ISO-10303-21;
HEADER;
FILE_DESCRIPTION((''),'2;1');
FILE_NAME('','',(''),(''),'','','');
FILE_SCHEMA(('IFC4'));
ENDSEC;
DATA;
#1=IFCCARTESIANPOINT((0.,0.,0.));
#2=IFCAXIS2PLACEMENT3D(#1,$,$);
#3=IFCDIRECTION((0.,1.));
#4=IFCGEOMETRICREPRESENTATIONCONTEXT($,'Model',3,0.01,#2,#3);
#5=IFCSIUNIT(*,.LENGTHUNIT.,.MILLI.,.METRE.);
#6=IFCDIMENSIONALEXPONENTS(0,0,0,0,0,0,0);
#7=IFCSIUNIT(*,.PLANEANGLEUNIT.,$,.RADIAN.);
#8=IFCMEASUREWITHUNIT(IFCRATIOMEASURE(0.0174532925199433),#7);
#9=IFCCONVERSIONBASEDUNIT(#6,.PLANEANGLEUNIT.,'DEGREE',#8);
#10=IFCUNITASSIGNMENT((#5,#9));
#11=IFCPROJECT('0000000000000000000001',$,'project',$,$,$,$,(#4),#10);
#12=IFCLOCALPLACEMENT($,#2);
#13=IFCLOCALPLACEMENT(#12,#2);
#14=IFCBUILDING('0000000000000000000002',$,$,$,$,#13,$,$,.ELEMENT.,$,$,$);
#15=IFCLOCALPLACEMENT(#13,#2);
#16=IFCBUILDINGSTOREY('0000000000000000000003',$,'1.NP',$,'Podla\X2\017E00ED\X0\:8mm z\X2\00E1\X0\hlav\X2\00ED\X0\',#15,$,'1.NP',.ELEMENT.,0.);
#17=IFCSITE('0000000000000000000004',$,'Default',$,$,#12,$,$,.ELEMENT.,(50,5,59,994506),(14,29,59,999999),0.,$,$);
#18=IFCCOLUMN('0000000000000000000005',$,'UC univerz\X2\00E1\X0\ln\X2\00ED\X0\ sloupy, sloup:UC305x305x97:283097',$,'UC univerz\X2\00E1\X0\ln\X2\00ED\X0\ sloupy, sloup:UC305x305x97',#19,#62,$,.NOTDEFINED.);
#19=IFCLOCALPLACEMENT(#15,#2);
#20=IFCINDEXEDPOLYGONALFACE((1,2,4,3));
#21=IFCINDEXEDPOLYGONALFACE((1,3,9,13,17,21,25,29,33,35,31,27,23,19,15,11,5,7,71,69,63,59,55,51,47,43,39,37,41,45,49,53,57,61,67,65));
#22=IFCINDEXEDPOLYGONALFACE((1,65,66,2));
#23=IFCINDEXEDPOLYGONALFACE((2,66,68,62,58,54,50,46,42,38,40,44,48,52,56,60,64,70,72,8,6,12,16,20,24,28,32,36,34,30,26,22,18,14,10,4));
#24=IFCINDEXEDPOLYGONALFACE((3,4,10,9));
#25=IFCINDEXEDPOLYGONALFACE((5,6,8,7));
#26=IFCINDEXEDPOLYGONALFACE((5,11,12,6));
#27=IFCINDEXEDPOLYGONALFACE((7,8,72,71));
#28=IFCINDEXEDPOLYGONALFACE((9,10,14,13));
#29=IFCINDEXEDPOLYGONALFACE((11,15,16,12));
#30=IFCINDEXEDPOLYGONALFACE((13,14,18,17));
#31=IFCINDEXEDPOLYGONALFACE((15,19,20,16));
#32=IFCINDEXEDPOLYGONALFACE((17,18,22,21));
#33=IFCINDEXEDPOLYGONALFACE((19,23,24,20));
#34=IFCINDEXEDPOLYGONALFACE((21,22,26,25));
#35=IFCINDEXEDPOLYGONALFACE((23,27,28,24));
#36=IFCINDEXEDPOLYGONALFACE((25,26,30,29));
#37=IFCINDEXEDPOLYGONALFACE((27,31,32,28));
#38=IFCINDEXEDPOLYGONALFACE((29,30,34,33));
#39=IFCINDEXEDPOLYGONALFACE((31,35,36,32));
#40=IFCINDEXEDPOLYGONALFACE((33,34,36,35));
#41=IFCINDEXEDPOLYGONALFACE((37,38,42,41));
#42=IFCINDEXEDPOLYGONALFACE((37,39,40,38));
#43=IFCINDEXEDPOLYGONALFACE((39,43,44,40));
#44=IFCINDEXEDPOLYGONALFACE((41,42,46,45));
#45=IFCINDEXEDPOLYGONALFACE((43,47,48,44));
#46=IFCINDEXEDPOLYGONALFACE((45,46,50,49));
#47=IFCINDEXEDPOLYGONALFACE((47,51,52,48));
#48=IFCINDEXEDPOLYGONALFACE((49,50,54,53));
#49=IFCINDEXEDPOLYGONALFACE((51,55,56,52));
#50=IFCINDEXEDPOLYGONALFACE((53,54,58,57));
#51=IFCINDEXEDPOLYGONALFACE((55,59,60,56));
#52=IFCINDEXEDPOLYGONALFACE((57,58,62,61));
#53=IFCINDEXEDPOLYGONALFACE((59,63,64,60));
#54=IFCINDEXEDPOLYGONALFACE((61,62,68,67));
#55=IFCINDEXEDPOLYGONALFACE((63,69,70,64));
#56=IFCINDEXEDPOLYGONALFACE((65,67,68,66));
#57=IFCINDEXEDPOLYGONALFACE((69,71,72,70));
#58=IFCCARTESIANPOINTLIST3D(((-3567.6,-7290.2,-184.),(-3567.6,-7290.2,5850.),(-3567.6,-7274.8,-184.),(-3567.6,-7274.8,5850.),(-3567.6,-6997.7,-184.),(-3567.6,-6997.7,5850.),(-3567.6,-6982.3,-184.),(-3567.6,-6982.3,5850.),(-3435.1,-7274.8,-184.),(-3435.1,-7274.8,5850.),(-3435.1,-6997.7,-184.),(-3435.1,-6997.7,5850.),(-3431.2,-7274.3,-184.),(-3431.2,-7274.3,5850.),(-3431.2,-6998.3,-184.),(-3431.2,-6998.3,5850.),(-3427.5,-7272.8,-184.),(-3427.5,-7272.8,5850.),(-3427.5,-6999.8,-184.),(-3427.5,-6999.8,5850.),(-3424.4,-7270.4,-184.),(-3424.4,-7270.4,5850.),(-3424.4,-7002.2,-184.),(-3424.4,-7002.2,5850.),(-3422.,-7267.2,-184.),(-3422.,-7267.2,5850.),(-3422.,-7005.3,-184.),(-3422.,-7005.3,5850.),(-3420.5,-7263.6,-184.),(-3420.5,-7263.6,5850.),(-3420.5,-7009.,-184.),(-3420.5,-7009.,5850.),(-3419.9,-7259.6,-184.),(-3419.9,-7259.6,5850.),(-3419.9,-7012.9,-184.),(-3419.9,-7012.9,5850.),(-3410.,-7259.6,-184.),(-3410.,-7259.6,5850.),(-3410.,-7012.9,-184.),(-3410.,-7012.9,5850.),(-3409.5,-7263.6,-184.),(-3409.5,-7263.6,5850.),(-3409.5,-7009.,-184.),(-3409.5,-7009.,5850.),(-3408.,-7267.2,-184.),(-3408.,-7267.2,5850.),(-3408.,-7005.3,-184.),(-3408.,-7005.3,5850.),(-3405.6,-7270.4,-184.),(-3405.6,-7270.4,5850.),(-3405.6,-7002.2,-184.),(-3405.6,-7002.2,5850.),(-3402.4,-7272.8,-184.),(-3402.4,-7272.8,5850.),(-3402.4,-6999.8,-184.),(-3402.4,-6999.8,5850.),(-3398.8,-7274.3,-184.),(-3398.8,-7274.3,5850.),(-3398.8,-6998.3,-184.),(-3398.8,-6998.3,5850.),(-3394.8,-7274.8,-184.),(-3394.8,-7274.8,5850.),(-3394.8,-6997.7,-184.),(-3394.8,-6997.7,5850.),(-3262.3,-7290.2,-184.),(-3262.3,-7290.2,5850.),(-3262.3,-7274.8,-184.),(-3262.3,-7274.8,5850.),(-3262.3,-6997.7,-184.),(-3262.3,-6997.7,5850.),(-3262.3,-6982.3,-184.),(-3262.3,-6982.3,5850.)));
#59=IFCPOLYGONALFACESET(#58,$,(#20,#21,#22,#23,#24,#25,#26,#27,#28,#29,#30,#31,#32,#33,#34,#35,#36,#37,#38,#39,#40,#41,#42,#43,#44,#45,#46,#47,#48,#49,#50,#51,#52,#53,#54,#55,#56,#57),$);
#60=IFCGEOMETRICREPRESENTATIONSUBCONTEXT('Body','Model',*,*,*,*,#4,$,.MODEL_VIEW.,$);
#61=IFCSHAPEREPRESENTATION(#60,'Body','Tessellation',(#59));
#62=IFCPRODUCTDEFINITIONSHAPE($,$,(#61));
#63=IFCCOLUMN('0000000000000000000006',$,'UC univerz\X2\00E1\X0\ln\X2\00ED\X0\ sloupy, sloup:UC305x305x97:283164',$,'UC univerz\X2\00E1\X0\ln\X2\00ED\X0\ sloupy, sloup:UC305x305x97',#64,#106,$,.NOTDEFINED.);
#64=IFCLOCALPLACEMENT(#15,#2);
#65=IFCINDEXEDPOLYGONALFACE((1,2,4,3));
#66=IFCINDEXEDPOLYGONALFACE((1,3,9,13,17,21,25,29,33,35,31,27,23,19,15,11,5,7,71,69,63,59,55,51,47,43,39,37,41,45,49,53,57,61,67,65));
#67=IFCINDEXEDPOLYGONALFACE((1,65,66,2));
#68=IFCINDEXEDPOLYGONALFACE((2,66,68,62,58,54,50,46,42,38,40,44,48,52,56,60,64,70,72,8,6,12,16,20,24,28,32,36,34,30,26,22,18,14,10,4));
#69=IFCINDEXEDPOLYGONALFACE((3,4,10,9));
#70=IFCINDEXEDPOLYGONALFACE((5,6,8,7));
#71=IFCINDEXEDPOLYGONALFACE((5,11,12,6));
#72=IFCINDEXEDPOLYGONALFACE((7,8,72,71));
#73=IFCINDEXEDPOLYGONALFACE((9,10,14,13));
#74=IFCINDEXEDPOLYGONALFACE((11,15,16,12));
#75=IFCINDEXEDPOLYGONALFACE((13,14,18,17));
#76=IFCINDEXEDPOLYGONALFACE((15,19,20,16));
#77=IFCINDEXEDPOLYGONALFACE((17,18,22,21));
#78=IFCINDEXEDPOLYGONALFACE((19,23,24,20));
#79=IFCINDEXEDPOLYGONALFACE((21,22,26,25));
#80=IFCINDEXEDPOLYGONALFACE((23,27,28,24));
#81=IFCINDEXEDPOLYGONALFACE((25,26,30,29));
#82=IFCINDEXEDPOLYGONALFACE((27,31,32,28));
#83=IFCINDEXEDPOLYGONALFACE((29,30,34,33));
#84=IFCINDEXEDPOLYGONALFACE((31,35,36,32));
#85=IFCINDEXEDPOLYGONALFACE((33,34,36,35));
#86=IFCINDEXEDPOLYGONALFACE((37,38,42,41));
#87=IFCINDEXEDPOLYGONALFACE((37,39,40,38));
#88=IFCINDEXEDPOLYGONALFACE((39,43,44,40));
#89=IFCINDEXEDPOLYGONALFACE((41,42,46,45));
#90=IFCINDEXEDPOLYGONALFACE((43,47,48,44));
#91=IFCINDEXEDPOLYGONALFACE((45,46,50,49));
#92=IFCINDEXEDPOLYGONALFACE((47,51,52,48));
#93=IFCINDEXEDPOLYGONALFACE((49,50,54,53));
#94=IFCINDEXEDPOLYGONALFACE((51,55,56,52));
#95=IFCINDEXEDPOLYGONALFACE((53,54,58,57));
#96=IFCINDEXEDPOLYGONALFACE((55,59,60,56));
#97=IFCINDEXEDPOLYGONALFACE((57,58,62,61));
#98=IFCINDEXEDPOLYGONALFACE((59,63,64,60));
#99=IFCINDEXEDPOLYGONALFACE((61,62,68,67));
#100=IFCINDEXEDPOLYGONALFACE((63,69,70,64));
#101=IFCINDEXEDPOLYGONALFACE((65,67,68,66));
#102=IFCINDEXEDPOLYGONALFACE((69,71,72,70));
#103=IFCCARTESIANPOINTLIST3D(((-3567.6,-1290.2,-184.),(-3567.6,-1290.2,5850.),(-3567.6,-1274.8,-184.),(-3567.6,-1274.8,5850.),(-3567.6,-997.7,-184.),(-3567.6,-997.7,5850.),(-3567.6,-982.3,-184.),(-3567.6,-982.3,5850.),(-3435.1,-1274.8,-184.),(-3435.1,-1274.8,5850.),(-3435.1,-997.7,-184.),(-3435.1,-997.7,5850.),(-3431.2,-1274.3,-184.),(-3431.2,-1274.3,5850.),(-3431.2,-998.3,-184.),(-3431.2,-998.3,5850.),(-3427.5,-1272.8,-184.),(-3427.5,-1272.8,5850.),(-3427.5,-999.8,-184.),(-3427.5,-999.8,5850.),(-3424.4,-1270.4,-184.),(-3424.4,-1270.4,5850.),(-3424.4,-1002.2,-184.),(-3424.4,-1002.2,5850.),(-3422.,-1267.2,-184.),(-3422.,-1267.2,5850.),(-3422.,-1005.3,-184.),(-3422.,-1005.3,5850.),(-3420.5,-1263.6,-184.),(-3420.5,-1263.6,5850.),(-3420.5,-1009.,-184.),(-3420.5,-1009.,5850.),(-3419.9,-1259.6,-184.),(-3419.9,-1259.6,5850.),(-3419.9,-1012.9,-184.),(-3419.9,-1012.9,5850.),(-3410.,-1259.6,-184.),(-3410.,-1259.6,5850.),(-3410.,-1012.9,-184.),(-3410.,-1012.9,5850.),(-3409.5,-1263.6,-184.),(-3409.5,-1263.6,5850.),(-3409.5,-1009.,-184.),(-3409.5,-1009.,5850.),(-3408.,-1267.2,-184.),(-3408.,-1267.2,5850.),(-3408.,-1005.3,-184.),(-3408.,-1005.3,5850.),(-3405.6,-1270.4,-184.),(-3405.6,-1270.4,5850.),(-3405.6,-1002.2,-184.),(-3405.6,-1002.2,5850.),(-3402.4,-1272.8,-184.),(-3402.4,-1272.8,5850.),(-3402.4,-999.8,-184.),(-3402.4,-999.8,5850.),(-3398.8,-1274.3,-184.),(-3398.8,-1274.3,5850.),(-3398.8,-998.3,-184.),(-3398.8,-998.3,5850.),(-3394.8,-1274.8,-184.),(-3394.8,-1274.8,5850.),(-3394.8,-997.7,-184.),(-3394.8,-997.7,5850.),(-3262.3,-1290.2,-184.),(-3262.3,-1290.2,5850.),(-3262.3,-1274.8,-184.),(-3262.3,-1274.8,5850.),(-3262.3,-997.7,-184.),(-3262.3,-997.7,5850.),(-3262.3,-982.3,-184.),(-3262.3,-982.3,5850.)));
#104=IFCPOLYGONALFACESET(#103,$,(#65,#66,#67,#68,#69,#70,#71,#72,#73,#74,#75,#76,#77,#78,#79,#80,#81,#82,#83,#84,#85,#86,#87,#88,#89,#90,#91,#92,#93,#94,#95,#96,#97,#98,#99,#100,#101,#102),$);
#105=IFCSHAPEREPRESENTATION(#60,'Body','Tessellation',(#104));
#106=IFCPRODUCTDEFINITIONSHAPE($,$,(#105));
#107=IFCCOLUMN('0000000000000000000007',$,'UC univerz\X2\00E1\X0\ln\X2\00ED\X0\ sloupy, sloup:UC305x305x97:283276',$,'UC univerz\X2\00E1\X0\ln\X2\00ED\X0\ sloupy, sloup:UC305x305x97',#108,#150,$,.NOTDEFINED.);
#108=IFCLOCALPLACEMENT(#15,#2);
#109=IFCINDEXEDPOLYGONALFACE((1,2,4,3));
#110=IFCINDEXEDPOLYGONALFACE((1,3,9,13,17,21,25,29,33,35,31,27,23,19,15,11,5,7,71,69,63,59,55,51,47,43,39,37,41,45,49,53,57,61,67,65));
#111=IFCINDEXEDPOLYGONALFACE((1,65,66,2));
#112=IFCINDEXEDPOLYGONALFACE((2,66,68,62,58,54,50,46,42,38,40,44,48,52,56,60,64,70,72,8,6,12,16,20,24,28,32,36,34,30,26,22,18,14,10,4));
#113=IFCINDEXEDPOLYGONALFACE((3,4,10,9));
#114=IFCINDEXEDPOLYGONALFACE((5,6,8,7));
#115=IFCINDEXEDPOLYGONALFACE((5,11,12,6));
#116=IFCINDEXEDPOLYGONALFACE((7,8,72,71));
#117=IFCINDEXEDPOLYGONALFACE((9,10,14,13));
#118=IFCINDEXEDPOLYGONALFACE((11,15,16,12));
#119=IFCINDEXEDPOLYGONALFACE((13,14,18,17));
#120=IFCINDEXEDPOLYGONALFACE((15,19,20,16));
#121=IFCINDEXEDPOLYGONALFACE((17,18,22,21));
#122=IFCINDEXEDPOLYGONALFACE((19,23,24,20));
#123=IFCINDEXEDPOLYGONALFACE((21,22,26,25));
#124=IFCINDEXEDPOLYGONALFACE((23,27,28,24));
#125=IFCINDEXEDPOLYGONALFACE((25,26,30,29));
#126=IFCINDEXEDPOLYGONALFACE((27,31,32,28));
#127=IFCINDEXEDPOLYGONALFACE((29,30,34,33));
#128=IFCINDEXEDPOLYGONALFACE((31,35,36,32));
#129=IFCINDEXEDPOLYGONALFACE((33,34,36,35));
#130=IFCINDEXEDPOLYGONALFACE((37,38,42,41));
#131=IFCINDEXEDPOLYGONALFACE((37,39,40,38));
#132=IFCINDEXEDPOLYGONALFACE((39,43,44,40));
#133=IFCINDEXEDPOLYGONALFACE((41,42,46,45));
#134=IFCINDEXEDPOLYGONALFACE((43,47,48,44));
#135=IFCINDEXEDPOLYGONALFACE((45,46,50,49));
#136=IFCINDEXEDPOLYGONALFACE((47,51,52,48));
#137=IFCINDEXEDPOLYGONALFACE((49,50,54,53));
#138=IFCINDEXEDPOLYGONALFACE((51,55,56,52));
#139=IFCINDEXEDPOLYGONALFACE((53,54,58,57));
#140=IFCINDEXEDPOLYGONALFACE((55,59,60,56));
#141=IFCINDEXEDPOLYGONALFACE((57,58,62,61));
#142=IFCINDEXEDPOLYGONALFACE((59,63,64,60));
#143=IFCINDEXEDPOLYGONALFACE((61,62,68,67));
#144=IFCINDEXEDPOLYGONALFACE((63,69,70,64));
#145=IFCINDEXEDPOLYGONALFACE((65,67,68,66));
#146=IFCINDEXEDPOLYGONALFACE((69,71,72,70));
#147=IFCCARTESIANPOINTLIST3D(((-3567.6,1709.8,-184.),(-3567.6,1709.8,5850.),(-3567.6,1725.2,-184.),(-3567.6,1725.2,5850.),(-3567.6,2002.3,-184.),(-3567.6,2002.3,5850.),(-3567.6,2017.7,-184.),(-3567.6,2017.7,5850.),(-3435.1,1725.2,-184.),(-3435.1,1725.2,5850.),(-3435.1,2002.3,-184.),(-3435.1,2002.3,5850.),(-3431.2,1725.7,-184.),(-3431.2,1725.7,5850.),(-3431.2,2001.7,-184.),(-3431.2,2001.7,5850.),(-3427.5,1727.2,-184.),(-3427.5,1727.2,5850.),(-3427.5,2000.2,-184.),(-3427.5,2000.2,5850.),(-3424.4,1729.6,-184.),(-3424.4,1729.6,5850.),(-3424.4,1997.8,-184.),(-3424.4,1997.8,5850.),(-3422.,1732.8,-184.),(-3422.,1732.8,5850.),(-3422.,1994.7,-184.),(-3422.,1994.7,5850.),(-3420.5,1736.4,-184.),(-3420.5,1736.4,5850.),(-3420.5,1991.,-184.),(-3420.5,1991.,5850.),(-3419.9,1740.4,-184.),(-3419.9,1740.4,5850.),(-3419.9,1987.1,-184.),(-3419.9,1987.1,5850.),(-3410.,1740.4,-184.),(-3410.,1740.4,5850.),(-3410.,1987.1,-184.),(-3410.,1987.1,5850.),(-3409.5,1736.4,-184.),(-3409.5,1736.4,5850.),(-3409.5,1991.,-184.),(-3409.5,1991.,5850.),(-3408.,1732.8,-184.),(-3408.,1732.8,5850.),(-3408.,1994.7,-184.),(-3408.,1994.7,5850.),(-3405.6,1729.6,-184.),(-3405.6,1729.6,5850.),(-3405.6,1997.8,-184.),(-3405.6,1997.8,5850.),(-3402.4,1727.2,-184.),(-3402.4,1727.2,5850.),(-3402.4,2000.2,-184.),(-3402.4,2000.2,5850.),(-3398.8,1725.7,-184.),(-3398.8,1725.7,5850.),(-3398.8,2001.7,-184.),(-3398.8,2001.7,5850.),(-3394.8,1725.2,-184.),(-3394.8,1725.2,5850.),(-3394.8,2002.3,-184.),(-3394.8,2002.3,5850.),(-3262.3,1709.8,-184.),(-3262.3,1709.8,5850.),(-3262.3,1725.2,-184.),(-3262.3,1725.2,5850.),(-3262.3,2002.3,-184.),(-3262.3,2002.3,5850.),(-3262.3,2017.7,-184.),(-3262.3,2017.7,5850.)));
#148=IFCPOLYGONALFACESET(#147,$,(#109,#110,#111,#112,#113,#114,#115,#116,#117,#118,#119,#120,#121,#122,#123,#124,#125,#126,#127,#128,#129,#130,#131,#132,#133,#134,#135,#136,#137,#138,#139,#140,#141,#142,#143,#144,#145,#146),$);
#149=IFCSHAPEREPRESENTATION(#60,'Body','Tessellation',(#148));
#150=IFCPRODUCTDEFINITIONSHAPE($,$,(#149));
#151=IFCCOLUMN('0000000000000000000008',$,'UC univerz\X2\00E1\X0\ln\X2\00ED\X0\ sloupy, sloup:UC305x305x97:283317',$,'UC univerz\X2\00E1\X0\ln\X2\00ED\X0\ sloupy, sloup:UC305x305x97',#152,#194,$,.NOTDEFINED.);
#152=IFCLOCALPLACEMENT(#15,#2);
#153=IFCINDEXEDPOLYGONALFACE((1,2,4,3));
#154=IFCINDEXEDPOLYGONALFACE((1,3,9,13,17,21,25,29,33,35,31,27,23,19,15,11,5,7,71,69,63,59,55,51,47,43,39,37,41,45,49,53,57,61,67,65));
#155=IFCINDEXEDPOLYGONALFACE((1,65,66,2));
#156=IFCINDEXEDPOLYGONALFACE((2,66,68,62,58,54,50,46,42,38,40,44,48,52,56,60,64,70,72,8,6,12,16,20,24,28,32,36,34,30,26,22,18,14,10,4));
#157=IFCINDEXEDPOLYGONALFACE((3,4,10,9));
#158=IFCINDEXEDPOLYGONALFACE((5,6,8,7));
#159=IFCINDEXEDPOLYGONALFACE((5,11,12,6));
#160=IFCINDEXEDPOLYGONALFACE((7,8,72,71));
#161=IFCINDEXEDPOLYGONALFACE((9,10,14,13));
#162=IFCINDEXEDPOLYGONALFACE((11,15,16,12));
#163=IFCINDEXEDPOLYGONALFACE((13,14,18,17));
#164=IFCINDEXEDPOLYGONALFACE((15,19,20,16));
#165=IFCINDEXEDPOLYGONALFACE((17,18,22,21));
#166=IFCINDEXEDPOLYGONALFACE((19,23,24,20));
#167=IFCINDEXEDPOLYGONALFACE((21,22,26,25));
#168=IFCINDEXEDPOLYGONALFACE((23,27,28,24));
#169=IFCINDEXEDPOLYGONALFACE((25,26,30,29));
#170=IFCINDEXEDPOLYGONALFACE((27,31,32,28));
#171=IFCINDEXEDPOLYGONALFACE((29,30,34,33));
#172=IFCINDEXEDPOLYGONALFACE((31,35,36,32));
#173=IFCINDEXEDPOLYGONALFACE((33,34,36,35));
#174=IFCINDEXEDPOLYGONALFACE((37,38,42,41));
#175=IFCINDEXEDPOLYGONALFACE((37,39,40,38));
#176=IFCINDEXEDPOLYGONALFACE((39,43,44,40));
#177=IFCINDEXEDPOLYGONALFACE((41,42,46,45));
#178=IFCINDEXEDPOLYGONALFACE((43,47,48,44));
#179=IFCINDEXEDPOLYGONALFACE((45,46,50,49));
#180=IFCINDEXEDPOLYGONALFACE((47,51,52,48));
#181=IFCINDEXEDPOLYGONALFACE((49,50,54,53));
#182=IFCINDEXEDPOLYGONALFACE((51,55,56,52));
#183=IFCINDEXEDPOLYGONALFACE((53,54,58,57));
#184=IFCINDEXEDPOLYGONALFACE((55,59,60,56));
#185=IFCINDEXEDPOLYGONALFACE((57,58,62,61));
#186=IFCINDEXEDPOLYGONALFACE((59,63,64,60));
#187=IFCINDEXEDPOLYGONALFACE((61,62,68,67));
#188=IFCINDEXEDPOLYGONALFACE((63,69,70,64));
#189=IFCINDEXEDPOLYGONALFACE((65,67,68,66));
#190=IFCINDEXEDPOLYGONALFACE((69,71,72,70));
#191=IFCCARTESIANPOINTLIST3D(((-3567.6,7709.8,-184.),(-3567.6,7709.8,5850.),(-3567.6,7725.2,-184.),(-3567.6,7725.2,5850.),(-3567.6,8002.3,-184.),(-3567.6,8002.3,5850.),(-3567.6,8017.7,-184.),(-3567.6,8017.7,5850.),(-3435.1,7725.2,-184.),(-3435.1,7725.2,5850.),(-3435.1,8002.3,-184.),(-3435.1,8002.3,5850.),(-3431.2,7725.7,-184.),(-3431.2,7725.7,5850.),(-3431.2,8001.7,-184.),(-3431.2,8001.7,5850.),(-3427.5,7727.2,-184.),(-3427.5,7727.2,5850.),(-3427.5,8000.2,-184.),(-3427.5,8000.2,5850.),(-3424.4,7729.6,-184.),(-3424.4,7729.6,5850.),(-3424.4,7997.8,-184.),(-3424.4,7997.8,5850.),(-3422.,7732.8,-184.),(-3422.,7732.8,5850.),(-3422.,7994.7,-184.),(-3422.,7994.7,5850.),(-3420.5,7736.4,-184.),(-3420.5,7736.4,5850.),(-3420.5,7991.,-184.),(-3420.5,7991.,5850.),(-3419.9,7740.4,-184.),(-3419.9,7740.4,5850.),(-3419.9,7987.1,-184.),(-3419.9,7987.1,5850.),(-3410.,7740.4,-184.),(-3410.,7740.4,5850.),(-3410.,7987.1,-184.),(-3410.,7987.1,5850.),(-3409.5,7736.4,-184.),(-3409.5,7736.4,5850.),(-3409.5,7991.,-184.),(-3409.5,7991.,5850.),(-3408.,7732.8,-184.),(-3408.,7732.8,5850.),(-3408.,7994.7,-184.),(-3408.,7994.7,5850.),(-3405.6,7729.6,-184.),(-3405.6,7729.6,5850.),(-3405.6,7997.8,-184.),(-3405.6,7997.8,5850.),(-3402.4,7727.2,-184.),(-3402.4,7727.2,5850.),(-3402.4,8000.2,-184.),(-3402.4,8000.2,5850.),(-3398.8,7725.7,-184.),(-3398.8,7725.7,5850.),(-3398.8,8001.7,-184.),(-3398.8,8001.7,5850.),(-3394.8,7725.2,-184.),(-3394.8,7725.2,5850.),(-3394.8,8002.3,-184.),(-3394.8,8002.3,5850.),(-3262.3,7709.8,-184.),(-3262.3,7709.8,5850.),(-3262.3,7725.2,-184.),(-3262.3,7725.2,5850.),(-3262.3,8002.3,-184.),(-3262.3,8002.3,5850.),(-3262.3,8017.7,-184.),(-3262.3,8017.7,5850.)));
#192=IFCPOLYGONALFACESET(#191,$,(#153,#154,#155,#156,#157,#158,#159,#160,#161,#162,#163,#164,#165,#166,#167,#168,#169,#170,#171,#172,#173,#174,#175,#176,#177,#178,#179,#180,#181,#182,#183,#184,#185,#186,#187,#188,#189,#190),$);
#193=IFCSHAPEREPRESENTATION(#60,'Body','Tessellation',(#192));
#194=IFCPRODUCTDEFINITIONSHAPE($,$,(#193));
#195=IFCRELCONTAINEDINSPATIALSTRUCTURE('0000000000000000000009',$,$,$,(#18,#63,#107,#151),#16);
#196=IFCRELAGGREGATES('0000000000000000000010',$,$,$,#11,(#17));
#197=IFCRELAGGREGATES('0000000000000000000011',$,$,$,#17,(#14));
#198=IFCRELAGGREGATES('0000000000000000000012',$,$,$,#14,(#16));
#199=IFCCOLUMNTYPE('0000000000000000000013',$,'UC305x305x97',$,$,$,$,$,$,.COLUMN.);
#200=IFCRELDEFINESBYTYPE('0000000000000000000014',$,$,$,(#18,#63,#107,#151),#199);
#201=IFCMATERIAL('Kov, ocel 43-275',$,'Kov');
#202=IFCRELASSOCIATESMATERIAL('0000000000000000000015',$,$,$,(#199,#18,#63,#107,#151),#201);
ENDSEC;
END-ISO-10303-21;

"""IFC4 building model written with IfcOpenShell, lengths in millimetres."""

from ifc_helpers import new_model, entity, si_unit, converted_unit, direction, frame, frame_2d, origin, place, context, subcontext, project, spatial, i_section, extrude, source, transform, mapped, material, material_profile, profile_set, profile_usage, type_object, type_shapes, element, save


model = new_model("IFC4")

# Units and contexts
model_context = context("Model", 3, precision=0.01, world=origin(), true_north=direction((0.0, 1.0)))
body_context = subcontext(model_context, "Body", "Model", "MODEL_VIEW")
ifc_project = project(units=[si_unit("LENGTHUNIT", "METRE", prefix="MILLI"), converted_unit("PLANEANGLEUNIT", "DEGREE", entity("IfcRatioMeasure", 0.0174532925199433), si_unit("PLANEANGLEUNIT", "RADIAN"), dimensions=[0, 0, 0, 0, 0, 0, 0])], contexts=[model_context])

# Site, building, storey
site_placement = place(None, origin())
site = spatial("IfcSite", under=ifc_project, at=site_placement, Name="Default", CompositionType="ELEMENT", RefLatitude=(50, 5, 59, 994506), RefLongitude=(14, 29, 59, 999999), RefElevation=0.0)
building_placement = place(site_placement, origin())
building = spatial("IfcBuilding", under=site, at=building_placement, CompositionType="ELEMENT")
storey_placement = place(building_placement, origin())
storey = spatial("IfcBuildingStorey", under=building, at=storey_placement, Name="1.NP", ObjectType="Podlaží:8mm záhlaví", LongName="1.NP", CompositionType="ELEMENT", Elevation=0.0)

# Columns
ifc_material_1 = material(Name="Kov, ocel 43-275", Category="Kov")
ifc_material_profile = material_profile(ifc_material_1, i_section(OverallWidth=305.3, OverallDepth=307.9, WebThickness=9.9, FlangeThickness=15.4, FilletRadius=15.2, at=frame_2d((0.0, 0.0), x_axis=(0.0, 1.0))), Name="UC305x305x97")
ifc_profile_set = profile_set([ifc_material_profile], Name="UC305x305x97")
ifc_profile_usage_1 = profile_usage(ifc_profile_set)
column_type = type_object("IfcColumnType", Name="UC305x305x97", PredefinedType="COLUMN", material=ifc_profile_set)
shared_shape_1 = source(origin(), body_context, "Body", "SweptSolid", [
    extrude(i_section(OverallWidth=305.3, OverallDepth=307.9, WebThickness=9.9, FlangeThickness=15.4, FilletRadius=15.2, at=frame_2d((0.0, 0.0), x_axis=(0.0, 1.0))), frame((0.0, 0.0, -184.0), z_axis=(0.0, 0.0, 1.0), x_axis=(0.0, -1.0, 0.0)), (0.0, 0.0, 1.0), 6034.0),
])
type_shapes(column_type, [shared_shape_1])
column_1_placement = place(storey_placement, frame((-3415.0, -7136.3, 0.0)))
element("IfcColumn", 1, at=column_1_placement, inside=storey, type_object=column_type, material=ifc_profile_usage_1, Name="UC univerzální sloupy, sloup:UC305x305x97:283097", ObjectType="UC univerzální sloupy, sloup:UC305x305x97", PredefinedType="NOTDEFINED", context=body_context, shape_type="MappedRepresentation", body=[
    mapped(shared_shape_1, transform((0.0, 0.0, 0.0), scale=1.0)),
])
ifc_profile_usage_2 = profile_usage(ifc_profile_set)
column_2_placement = place(storey_placement, frame((-3415.0, -1136.3, 0.0)))
element("IfcColumn", 2, at=column_2_placement, inside=storey, type_object=column_type, material=ifc_profile_usage_2, Name="UC univerzální sloupy, sloup:UC305x305x97:283164", ObjectType="UC univerzální sloupy, sloup:UC305x305x97", PredefinedType="NOTDEFINED", context=body_context, shape_type="MappedRepresentation", body=[
    mapped(shared_shape_1, transform((0.0, 0.0, 0.0), scale=1.0)),
])
ifc_profile_usage_3 = profile_usage(ifc_profile_set)
column_3_placement = place(storey_placement, frame((-3415.0, 1863.7, 0.0)))
element("IfcColumn", 3, at=column_3_placement, inside=storey, type_object=column_type, material=ifc_profile_usage_3, Name="UC univerzální sloupy, sloup:UC305x305x97:283276", ObjectType="UC univerzální sloupy, sloup:UC305x305x97", PredefinedType="NOTDEFINED", context=body_context, shape_type="MappedRepresentation", body=[
    mapped(shared_shape_1, transform((0.0, 0.0, 0.0), scale=1.0)),
])
ifc_profile_usage_4 = profile_usage(ifc_profile_set)
column_4_placement = place(storey_placement, frame((-3415.0, 7863.7, 0.0)))
element("IfcColumn", 4, at=column_4_placement, inside=storey, type_object=column_type, material=ifc_profile_usage_4, Name="UC univerzální sloupy, sloup:UC305x305x97:283317", ObjectType="UC univerzální sloupy, sloup:UC305x305x97", PredefinedType="NOTDEFINED", context=body_context, shape_type="MappedRepresentation", body=[
    mapped(shared_shape_1, transform((0.0, 0.0, 0.0), scale=1.0)),
])

save(model, "model.ifc")
